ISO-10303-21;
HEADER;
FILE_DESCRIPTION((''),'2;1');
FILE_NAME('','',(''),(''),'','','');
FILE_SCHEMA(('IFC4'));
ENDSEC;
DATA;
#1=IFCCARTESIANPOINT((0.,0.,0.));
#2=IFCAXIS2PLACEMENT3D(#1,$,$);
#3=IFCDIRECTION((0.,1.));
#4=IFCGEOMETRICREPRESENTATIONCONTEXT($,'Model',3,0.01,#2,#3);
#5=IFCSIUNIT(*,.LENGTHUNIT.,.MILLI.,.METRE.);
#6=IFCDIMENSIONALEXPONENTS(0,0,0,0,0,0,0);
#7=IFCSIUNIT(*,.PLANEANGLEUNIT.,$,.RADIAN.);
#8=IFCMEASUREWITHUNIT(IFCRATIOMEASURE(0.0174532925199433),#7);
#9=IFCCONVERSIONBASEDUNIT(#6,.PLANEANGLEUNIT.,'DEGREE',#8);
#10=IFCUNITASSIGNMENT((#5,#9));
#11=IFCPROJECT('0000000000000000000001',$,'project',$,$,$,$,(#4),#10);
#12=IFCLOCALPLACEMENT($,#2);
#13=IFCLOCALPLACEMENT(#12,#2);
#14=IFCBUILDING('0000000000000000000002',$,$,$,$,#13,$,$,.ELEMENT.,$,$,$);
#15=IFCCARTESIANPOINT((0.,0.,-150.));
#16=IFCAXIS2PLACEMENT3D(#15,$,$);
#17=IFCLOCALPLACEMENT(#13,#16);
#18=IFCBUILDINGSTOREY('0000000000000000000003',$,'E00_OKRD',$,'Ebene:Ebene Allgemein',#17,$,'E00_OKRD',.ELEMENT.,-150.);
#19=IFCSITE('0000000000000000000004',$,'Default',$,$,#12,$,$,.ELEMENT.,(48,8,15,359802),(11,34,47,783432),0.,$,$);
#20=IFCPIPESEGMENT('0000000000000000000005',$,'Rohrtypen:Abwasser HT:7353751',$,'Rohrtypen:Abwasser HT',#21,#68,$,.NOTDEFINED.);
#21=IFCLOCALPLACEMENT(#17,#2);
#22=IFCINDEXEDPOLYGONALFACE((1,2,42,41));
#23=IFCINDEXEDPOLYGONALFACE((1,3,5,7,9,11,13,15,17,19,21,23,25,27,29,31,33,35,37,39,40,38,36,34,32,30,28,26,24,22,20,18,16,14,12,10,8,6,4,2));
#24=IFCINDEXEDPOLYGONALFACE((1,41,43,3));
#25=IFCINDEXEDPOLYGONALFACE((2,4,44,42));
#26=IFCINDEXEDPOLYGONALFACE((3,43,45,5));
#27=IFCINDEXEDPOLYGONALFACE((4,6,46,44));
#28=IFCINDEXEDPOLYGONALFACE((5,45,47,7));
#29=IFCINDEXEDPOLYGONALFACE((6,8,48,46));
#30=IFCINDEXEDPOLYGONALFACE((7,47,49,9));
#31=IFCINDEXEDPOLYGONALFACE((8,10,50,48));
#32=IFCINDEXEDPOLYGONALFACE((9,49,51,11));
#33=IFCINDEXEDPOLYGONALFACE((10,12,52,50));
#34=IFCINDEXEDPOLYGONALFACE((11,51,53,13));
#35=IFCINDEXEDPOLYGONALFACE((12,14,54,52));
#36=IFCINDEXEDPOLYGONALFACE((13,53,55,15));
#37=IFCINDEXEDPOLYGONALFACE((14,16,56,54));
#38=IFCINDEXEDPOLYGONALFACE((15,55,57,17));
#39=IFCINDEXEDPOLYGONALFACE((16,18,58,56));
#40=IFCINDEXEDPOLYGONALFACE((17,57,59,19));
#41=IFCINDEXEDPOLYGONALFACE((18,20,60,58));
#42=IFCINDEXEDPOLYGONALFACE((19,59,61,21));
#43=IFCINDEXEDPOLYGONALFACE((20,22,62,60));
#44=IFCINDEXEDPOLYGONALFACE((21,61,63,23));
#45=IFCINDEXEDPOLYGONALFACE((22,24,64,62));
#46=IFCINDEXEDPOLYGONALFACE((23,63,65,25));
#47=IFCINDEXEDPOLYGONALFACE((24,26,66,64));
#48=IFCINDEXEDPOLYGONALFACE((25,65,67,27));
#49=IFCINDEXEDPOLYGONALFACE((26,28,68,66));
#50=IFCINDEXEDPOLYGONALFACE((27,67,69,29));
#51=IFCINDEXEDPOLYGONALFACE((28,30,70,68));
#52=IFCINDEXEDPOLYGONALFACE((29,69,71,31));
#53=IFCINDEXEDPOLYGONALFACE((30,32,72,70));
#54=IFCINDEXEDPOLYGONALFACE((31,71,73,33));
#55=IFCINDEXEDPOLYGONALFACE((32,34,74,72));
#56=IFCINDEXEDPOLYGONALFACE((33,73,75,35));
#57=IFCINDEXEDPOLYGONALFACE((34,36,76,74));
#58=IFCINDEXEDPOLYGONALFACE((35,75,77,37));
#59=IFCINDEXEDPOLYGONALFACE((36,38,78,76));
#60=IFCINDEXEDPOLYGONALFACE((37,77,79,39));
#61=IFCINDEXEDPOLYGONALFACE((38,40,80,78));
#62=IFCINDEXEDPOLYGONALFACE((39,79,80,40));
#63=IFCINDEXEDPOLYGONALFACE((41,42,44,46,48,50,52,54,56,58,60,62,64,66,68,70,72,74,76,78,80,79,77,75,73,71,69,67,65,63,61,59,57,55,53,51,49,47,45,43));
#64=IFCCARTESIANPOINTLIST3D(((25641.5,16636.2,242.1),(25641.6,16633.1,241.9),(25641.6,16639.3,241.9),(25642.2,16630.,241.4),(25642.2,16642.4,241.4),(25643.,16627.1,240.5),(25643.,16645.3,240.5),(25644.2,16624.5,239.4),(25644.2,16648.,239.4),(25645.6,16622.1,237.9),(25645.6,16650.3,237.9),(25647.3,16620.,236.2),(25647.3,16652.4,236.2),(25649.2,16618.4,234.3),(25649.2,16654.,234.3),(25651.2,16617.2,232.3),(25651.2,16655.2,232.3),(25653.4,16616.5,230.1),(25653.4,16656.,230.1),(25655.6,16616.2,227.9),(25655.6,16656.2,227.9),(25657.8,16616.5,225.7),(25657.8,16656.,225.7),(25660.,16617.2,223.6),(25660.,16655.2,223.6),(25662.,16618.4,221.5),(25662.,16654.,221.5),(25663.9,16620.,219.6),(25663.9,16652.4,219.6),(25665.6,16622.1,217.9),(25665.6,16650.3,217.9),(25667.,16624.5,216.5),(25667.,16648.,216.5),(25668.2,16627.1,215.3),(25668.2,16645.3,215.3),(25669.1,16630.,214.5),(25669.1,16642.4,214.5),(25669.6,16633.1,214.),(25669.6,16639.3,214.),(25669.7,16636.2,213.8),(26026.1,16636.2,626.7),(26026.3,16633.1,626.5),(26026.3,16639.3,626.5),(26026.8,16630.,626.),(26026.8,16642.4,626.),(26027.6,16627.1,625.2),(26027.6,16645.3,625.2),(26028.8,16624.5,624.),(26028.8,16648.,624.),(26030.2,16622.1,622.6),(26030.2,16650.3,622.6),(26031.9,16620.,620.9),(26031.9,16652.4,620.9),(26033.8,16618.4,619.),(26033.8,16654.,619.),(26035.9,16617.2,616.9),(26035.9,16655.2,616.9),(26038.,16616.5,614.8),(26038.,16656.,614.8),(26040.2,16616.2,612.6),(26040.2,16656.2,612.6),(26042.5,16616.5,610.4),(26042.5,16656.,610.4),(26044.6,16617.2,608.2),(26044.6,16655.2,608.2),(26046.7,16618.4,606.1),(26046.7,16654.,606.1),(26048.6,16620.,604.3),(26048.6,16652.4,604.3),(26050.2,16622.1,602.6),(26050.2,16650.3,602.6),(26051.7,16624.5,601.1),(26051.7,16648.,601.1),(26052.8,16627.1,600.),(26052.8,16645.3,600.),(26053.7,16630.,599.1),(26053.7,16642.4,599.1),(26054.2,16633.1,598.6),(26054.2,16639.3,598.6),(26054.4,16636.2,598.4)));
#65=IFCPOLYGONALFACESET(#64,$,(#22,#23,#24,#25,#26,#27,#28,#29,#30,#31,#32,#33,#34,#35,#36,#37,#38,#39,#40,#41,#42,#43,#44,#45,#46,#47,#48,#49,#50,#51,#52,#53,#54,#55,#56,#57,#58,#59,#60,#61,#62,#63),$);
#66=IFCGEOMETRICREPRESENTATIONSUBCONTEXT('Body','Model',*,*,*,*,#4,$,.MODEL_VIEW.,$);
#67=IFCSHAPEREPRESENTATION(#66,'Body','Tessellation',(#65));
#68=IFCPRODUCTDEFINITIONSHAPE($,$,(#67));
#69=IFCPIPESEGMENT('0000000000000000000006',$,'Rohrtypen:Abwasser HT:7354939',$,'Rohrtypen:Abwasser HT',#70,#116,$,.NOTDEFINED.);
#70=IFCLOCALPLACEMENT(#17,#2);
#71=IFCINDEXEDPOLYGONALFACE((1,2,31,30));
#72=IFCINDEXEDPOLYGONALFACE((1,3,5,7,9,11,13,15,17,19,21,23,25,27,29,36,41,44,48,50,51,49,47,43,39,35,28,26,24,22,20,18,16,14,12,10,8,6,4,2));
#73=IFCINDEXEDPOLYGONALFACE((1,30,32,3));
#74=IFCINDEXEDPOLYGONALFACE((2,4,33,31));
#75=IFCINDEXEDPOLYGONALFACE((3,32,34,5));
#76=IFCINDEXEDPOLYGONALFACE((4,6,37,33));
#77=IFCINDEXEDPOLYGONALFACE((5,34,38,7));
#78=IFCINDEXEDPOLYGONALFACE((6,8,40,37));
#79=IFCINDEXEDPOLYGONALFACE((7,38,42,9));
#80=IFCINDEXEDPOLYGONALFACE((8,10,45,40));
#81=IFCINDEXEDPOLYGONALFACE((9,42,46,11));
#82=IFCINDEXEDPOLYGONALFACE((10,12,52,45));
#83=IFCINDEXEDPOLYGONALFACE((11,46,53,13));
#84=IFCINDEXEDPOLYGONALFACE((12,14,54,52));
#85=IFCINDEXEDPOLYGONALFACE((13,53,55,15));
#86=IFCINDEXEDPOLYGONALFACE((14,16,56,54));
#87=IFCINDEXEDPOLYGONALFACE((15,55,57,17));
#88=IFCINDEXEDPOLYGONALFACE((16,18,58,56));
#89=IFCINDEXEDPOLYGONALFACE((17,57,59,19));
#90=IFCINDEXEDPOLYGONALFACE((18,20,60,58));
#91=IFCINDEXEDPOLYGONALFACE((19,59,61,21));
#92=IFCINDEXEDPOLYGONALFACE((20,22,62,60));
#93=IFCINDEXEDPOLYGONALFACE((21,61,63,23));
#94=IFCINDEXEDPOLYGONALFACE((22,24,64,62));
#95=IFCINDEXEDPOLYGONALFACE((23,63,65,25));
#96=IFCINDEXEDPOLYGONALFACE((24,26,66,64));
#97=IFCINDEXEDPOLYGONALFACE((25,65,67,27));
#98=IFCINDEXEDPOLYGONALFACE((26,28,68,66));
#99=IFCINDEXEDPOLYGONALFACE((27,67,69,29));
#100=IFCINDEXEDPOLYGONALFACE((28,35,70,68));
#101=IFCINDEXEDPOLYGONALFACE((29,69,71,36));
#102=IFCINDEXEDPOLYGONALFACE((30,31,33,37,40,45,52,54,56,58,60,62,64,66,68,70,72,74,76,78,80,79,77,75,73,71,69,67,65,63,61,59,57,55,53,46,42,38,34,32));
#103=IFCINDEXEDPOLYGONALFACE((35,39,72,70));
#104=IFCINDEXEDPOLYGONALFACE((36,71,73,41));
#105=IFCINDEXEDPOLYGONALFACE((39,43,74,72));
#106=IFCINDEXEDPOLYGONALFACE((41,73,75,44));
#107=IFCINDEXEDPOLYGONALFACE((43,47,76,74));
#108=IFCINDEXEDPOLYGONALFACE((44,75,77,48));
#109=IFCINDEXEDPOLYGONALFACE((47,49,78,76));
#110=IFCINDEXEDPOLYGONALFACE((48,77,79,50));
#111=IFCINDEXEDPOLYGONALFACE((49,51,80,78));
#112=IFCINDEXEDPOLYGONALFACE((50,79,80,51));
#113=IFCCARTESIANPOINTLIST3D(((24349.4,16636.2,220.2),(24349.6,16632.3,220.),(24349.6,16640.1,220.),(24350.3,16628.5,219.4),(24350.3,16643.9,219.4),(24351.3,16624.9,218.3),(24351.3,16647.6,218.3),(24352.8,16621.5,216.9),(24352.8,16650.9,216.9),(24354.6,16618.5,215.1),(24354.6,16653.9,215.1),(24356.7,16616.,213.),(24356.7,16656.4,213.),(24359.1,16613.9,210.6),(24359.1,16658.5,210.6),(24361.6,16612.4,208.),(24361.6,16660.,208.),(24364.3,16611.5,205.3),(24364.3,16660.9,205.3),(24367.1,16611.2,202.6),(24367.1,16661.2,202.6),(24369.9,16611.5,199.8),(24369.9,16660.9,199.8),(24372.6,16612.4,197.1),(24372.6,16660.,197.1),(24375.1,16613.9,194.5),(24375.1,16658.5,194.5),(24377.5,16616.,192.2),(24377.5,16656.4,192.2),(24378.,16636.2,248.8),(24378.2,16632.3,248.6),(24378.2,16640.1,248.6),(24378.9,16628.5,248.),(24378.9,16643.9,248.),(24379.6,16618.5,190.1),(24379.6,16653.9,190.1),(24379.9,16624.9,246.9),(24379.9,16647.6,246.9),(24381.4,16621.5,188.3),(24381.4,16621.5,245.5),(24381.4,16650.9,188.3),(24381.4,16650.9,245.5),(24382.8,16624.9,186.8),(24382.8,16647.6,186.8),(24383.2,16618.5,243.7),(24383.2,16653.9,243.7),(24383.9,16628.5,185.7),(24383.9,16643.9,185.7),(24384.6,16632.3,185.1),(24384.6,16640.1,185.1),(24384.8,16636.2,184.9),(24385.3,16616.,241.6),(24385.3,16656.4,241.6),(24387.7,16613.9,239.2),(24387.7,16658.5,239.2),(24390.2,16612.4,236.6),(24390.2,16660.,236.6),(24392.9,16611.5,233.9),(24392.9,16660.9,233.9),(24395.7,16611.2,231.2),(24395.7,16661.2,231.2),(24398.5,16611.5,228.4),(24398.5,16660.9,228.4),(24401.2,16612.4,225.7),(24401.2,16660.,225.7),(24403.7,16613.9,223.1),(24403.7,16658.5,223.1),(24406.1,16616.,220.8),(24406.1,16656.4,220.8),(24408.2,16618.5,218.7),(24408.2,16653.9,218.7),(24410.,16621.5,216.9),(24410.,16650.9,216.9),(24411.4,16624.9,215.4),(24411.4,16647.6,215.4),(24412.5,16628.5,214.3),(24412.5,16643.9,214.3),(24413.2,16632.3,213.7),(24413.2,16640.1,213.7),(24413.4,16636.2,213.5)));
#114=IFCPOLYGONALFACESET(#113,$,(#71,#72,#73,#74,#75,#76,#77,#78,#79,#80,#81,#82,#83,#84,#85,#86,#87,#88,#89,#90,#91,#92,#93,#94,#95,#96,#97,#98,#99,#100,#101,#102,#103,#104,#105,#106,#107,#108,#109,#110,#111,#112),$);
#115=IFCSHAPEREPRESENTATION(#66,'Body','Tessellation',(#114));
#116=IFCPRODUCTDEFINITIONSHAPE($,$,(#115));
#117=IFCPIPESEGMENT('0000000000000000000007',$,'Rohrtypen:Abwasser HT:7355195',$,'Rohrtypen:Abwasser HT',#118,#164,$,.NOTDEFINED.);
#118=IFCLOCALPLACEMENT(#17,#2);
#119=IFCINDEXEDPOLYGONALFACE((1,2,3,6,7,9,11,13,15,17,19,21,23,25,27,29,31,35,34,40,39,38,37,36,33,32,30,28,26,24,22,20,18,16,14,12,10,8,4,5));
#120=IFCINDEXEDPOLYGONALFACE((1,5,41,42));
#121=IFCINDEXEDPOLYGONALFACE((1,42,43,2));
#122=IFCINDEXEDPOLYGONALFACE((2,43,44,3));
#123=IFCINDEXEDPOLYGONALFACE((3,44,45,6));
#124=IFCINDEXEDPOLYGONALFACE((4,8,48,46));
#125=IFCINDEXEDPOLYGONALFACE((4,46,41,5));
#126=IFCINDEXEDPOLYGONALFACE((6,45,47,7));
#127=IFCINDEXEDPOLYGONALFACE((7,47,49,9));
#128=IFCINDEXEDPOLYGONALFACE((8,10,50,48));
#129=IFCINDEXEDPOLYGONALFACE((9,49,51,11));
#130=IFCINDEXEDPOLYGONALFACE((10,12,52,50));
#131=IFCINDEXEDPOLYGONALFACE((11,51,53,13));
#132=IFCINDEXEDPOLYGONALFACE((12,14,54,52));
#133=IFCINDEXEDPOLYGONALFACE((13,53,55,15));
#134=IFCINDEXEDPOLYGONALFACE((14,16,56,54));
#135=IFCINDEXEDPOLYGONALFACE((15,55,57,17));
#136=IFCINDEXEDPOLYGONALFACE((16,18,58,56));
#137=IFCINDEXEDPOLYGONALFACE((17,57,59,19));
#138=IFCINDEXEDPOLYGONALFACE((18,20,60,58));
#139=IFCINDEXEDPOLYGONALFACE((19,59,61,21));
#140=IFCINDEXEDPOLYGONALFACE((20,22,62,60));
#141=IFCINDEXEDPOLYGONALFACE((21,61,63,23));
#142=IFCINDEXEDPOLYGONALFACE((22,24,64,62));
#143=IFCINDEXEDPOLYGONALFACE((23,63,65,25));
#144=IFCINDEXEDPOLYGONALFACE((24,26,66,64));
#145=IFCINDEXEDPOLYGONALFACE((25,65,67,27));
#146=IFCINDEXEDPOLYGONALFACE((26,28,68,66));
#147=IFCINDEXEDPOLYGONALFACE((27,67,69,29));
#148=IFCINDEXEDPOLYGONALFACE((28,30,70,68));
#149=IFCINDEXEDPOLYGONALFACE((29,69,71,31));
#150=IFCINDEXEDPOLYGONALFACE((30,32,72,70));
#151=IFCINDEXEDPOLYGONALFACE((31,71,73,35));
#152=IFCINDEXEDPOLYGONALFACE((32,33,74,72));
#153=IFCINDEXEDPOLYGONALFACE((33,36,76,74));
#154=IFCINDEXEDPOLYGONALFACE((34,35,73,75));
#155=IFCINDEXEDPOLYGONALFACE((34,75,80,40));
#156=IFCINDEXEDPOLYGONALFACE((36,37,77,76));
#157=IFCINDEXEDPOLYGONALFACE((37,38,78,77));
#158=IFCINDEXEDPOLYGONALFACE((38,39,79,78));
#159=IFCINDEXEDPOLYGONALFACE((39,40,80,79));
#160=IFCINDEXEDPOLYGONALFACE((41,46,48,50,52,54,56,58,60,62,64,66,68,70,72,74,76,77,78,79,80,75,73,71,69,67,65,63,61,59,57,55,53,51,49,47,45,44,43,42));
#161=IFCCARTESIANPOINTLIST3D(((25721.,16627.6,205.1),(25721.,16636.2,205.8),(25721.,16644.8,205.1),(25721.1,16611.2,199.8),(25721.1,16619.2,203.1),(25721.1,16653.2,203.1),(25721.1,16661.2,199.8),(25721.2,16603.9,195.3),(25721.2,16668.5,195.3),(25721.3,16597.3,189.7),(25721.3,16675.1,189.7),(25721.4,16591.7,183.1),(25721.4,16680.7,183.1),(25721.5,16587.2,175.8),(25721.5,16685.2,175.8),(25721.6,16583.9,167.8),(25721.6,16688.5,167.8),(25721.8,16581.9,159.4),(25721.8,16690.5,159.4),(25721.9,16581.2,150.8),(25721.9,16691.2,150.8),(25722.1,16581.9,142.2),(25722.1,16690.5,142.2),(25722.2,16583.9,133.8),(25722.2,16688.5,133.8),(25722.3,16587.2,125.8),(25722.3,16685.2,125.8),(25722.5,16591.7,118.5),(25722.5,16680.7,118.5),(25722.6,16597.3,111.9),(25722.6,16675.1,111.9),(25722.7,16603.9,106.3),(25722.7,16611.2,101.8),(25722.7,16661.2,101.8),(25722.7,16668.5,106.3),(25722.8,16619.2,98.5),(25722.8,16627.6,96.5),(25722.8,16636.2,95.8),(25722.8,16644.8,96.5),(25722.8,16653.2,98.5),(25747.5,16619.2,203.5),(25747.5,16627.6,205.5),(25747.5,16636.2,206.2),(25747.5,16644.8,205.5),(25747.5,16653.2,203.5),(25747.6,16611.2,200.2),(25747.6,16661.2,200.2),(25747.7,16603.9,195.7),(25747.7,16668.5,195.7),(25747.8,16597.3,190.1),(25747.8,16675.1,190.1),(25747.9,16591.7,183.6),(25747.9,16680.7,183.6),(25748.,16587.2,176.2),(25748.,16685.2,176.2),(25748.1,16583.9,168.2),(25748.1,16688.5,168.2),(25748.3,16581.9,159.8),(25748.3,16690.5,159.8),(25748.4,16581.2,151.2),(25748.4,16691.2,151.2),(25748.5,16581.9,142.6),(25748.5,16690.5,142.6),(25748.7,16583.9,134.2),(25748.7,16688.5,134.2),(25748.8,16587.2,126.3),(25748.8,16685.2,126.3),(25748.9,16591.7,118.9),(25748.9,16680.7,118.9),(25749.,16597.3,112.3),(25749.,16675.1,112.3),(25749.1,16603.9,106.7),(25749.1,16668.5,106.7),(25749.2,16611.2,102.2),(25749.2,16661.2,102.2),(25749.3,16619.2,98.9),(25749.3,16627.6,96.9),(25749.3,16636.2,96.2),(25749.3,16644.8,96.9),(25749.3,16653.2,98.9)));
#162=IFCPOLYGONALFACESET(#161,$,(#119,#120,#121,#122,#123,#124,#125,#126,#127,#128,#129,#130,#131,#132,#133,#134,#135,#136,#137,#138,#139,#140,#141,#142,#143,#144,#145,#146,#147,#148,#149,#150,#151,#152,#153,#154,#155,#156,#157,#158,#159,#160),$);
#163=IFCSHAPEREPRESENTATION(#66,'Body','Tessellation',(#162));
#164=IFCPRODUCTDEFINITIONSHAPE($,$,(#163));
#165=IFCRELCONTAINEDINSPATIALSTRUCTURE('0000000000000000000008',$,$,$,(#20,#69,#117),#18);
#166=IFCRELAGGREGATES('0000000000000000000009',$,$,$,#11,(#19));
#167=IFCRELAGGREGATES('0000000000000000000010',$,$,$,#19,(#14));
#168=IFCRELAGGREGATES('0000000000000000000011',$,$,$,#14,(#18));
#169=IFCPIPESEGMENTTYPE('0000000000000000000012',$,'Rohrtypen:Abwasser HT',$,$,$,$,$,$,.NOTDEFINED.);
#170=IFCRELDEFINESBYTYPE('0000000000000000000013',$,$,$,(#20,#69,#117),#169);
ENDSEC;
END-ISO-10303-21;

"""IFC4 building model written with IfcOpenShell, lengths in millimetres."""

from ifc_helpers import new_model, entity, si_unit, converted_unit, direction, frame, origin, place, context, subcontext, project, spatial, indexed_curve, outline, extrude, type_object, element, save


model = new_model("IFC4")

# Units and contexts
model_context = context("Model", 3, precision=0.01, world=origin(), true_north=direction((0.0, 1.0)))
body_context = subcontext(model_context, "Body", "Model", "MODEL_VIEW")
ifc_project = project(units=[si_unit("LENGTHUNIT", "METRE", prefix="MILLI"), converted_unit("PLANEANGLEUNIT", "DEGREE", entity("IfcRatioMeasure", 0.0174532925199433), si_unit("PLANEANGLEUNIT", "RADIAN"), dimensions=[0, 0, 0, 0, 0, 0, 0])], contexts=[model_context])

# Site, building, storey
site_placement = place(None, origin())
site = spatial("IfcSite", under=ifc_project, at=site_placement, Name="Default", CompositionType="ELEMENT", RefLatitude=(48, 8, 15, 359802), RefLongitude=(11, 34, 47, 783432), RefElevation=0.0)
building_placement = place(site_placement, origin())
building = spatial("IfcBuilding", under=site, at=building_placement, CompositionType="ELEMENT")
storey_placement = place(building_placement, frame((0.0, 0.0, -150.0)))
storey = spatial("IfcBuildingStorey", under=building, at=storey_placement, Name="E00_OKRD", ObjectType="Ebene:Ebene Allgemein", LongName="E00_OKRD", CompositionType="ELEMENT", Elevation=-150.0)

# Pipe segments
pipe_segment_type_1 = type_object("IfcPipeSegmentType", Name="Rohrtypen:Abwasser HT", PredefinedType="NOTDEFINED")
pipe_segment_1_placement = place(storey_placement, origin())
element("IfcPipeSegment", 1, at=pipe_segment_1_placement, inside=storey, type_object=pipe_segment_type_1, Name="Rohrtypen:Abwasser HT:7353751", ObjectType="Rohrtypen:Abwasser HT", PredefinedType="NOTDEFINED", context=body_context, shape_type="SweptSolid", body=[
    extrude(outline(indexed_curve([(20.0, 0.0), (19.8, 3.1), (19.0, 6.2), (17.8, 9.1), (16.2, 11.8), (14.1, 14.1), (11.8, 16.2), (9.1, 17.8), (6.2, 19.0), (3.1, 19.8), (0.0, 20.0), (-3.1, 19.8), (-6.2, 19.0), (-9.1, 17.8), (-11.8, 16.2), (-14.1, 14.1), (-16.2, 11.8), (-17.8, 9.1), (-19.0, 6.2), (-19.8, 3.1), (-20.0, 0.0), (-19.8, -3.1), (-19.0, -6.2), (-17.8, -9.1), (-16.2, -11.8), (-14.1, -14.1), (-11.8, -16.2), (-9.1, -17.8), (-6.2, -19.0), (-3.1, -19.8), (0.0, -20.0), (3.1, -19.8), (6.2, -19.0), (9.1, -17.8), (11.8, -16.2), (14.1, -14.1), (16.2, -11.8), (17.8, -9.1), (19.0, -6.2), (19.8, -3.1), (20.0, 0.0)], self_intersect=False)), frame((25655.6, 16636.2, 227.9), z_axis=(0.707107, 0.0, 0.707107), x_axis=(0.0, 1.0, 0.0)), (0.0, 0.0, 1.0), 544.0),
])
pipe_segment_2_placement = place(storey_placement, origin())
element("IfcPipeSegment", 2, at=pipe_segment_2_placement, inside=storey, type_object=pipe_segment_type_1, Name="Rohrtypen:Abwasser HT:7354939", ObjectType="Rohrtypen:Abwasser HT", PredefinedType="NOTDEFINED", context=body_context, shape_type="SweptSolid", body=[
    extrude(outline(indexed_curve([(25.0, 0.0), (24.7, 3.9), (23.8, 7.7), (22.3, 11.3), (20.2, 14.7), (17.7, 17.7), (14.7, 20.2), (11.3, 22.3), (7.7, 23.8), (3.9, 24.7), (0.0, 25.0), (-3.9, 24.7), (-7.7, 23.8), (-11.3, 22.3), (-14.7, 20.2), (-17.7, 17.7), (-20.2, 14.7), (-22.3, 11.3), (-23.8, 7.7), (-24.7, 3.9), (-25.0, 0.0), (-24.7, -3.9), (-23.8, -7.7), (-22.3, -11.3), (-20.2, -14.7), (-17.7, -17.7), (-14.7, -20.2), (-11.3, -22.3), (-7.7, -23.8), (-3.9, -24.7), (0.0, -25.0), (3.9, -24.7), (7.7, -23.8), (11.3, -22.3), (14.7, -20.2), (17.7, -17.7), (20.2, -14.7), (22.3, -11.3), (23.8, -7.7), (24.7, -3.9), (25.0, 0.0)], self_intersect=False)), frame((24367.1, 16636.2, 202.6), z_axis=(0.707107, 0.0, 0.707107), x_axis=(0.0, -1.0, 0.0)), (0.0, 0.0, 1.0), 40.4),
])
pipe_segment_3_placement = place(storey_placement, origin())
element("IfcPipeSegment", 3, at=pipe_segment_3_placement, inside=storey, type_object=pipe_segment_type_1, Name="Rohrtypen:Abwasser HT:7355195", ObjectType="Rohrtypen:Abwasser HT", PredefinedType="NOTDEFINED", context=body_context, shape_type="SweptSolid", body=[
    extrude(outline(indexed_curve([(55.0, 0.0), (54.3, 8.6), (52.3, 17.0), (49.0, 25.0), (44.5, 32.3), (38.9, 38.9), (32.3, 44.5), (25.0, 49.0), (17.0, 52.3), (8.6, 54.3), (0.0, 55.0), (-8.6, 54.3), (-17.0, 52.3), (-25.0, 49.0), (-32.3, 44.5), (-38.9, 38.9), (-44.5, 32.3), (-49.0, 25.0), (-52.3, 17.0), (-54.3, 8.6), (-55.0, 0.0), (-54.3, -8.6), (-52.3, -17.0), (-49.0, -25.0), (-44.5, -32.3), (-38.9, -38.9), (-32.3, -44.5), (-25.0, -49.0), (-17.0, -52.3), (-8.6, -54.3), (0.0, -55.0), (8.6, -54.3), (17.0, -52.3), (25.0, -49.0), (32.3, -44.5), (38.9, -38.9), (44.5, -32.3), (49.0, -25.0), (52.3, -17.0), (54.3, -8.6), (55.0, 0.0)], self_intersect=False)), frame((25721.9, 16636.2, 150.8), z_axis=(0.999862, 0.0, 0.016604), x_axis=(0.0, -1.0, 0.0)), (0.0, 0.0, 1.0), 26.5),
])

save(model, "model.ifc")
